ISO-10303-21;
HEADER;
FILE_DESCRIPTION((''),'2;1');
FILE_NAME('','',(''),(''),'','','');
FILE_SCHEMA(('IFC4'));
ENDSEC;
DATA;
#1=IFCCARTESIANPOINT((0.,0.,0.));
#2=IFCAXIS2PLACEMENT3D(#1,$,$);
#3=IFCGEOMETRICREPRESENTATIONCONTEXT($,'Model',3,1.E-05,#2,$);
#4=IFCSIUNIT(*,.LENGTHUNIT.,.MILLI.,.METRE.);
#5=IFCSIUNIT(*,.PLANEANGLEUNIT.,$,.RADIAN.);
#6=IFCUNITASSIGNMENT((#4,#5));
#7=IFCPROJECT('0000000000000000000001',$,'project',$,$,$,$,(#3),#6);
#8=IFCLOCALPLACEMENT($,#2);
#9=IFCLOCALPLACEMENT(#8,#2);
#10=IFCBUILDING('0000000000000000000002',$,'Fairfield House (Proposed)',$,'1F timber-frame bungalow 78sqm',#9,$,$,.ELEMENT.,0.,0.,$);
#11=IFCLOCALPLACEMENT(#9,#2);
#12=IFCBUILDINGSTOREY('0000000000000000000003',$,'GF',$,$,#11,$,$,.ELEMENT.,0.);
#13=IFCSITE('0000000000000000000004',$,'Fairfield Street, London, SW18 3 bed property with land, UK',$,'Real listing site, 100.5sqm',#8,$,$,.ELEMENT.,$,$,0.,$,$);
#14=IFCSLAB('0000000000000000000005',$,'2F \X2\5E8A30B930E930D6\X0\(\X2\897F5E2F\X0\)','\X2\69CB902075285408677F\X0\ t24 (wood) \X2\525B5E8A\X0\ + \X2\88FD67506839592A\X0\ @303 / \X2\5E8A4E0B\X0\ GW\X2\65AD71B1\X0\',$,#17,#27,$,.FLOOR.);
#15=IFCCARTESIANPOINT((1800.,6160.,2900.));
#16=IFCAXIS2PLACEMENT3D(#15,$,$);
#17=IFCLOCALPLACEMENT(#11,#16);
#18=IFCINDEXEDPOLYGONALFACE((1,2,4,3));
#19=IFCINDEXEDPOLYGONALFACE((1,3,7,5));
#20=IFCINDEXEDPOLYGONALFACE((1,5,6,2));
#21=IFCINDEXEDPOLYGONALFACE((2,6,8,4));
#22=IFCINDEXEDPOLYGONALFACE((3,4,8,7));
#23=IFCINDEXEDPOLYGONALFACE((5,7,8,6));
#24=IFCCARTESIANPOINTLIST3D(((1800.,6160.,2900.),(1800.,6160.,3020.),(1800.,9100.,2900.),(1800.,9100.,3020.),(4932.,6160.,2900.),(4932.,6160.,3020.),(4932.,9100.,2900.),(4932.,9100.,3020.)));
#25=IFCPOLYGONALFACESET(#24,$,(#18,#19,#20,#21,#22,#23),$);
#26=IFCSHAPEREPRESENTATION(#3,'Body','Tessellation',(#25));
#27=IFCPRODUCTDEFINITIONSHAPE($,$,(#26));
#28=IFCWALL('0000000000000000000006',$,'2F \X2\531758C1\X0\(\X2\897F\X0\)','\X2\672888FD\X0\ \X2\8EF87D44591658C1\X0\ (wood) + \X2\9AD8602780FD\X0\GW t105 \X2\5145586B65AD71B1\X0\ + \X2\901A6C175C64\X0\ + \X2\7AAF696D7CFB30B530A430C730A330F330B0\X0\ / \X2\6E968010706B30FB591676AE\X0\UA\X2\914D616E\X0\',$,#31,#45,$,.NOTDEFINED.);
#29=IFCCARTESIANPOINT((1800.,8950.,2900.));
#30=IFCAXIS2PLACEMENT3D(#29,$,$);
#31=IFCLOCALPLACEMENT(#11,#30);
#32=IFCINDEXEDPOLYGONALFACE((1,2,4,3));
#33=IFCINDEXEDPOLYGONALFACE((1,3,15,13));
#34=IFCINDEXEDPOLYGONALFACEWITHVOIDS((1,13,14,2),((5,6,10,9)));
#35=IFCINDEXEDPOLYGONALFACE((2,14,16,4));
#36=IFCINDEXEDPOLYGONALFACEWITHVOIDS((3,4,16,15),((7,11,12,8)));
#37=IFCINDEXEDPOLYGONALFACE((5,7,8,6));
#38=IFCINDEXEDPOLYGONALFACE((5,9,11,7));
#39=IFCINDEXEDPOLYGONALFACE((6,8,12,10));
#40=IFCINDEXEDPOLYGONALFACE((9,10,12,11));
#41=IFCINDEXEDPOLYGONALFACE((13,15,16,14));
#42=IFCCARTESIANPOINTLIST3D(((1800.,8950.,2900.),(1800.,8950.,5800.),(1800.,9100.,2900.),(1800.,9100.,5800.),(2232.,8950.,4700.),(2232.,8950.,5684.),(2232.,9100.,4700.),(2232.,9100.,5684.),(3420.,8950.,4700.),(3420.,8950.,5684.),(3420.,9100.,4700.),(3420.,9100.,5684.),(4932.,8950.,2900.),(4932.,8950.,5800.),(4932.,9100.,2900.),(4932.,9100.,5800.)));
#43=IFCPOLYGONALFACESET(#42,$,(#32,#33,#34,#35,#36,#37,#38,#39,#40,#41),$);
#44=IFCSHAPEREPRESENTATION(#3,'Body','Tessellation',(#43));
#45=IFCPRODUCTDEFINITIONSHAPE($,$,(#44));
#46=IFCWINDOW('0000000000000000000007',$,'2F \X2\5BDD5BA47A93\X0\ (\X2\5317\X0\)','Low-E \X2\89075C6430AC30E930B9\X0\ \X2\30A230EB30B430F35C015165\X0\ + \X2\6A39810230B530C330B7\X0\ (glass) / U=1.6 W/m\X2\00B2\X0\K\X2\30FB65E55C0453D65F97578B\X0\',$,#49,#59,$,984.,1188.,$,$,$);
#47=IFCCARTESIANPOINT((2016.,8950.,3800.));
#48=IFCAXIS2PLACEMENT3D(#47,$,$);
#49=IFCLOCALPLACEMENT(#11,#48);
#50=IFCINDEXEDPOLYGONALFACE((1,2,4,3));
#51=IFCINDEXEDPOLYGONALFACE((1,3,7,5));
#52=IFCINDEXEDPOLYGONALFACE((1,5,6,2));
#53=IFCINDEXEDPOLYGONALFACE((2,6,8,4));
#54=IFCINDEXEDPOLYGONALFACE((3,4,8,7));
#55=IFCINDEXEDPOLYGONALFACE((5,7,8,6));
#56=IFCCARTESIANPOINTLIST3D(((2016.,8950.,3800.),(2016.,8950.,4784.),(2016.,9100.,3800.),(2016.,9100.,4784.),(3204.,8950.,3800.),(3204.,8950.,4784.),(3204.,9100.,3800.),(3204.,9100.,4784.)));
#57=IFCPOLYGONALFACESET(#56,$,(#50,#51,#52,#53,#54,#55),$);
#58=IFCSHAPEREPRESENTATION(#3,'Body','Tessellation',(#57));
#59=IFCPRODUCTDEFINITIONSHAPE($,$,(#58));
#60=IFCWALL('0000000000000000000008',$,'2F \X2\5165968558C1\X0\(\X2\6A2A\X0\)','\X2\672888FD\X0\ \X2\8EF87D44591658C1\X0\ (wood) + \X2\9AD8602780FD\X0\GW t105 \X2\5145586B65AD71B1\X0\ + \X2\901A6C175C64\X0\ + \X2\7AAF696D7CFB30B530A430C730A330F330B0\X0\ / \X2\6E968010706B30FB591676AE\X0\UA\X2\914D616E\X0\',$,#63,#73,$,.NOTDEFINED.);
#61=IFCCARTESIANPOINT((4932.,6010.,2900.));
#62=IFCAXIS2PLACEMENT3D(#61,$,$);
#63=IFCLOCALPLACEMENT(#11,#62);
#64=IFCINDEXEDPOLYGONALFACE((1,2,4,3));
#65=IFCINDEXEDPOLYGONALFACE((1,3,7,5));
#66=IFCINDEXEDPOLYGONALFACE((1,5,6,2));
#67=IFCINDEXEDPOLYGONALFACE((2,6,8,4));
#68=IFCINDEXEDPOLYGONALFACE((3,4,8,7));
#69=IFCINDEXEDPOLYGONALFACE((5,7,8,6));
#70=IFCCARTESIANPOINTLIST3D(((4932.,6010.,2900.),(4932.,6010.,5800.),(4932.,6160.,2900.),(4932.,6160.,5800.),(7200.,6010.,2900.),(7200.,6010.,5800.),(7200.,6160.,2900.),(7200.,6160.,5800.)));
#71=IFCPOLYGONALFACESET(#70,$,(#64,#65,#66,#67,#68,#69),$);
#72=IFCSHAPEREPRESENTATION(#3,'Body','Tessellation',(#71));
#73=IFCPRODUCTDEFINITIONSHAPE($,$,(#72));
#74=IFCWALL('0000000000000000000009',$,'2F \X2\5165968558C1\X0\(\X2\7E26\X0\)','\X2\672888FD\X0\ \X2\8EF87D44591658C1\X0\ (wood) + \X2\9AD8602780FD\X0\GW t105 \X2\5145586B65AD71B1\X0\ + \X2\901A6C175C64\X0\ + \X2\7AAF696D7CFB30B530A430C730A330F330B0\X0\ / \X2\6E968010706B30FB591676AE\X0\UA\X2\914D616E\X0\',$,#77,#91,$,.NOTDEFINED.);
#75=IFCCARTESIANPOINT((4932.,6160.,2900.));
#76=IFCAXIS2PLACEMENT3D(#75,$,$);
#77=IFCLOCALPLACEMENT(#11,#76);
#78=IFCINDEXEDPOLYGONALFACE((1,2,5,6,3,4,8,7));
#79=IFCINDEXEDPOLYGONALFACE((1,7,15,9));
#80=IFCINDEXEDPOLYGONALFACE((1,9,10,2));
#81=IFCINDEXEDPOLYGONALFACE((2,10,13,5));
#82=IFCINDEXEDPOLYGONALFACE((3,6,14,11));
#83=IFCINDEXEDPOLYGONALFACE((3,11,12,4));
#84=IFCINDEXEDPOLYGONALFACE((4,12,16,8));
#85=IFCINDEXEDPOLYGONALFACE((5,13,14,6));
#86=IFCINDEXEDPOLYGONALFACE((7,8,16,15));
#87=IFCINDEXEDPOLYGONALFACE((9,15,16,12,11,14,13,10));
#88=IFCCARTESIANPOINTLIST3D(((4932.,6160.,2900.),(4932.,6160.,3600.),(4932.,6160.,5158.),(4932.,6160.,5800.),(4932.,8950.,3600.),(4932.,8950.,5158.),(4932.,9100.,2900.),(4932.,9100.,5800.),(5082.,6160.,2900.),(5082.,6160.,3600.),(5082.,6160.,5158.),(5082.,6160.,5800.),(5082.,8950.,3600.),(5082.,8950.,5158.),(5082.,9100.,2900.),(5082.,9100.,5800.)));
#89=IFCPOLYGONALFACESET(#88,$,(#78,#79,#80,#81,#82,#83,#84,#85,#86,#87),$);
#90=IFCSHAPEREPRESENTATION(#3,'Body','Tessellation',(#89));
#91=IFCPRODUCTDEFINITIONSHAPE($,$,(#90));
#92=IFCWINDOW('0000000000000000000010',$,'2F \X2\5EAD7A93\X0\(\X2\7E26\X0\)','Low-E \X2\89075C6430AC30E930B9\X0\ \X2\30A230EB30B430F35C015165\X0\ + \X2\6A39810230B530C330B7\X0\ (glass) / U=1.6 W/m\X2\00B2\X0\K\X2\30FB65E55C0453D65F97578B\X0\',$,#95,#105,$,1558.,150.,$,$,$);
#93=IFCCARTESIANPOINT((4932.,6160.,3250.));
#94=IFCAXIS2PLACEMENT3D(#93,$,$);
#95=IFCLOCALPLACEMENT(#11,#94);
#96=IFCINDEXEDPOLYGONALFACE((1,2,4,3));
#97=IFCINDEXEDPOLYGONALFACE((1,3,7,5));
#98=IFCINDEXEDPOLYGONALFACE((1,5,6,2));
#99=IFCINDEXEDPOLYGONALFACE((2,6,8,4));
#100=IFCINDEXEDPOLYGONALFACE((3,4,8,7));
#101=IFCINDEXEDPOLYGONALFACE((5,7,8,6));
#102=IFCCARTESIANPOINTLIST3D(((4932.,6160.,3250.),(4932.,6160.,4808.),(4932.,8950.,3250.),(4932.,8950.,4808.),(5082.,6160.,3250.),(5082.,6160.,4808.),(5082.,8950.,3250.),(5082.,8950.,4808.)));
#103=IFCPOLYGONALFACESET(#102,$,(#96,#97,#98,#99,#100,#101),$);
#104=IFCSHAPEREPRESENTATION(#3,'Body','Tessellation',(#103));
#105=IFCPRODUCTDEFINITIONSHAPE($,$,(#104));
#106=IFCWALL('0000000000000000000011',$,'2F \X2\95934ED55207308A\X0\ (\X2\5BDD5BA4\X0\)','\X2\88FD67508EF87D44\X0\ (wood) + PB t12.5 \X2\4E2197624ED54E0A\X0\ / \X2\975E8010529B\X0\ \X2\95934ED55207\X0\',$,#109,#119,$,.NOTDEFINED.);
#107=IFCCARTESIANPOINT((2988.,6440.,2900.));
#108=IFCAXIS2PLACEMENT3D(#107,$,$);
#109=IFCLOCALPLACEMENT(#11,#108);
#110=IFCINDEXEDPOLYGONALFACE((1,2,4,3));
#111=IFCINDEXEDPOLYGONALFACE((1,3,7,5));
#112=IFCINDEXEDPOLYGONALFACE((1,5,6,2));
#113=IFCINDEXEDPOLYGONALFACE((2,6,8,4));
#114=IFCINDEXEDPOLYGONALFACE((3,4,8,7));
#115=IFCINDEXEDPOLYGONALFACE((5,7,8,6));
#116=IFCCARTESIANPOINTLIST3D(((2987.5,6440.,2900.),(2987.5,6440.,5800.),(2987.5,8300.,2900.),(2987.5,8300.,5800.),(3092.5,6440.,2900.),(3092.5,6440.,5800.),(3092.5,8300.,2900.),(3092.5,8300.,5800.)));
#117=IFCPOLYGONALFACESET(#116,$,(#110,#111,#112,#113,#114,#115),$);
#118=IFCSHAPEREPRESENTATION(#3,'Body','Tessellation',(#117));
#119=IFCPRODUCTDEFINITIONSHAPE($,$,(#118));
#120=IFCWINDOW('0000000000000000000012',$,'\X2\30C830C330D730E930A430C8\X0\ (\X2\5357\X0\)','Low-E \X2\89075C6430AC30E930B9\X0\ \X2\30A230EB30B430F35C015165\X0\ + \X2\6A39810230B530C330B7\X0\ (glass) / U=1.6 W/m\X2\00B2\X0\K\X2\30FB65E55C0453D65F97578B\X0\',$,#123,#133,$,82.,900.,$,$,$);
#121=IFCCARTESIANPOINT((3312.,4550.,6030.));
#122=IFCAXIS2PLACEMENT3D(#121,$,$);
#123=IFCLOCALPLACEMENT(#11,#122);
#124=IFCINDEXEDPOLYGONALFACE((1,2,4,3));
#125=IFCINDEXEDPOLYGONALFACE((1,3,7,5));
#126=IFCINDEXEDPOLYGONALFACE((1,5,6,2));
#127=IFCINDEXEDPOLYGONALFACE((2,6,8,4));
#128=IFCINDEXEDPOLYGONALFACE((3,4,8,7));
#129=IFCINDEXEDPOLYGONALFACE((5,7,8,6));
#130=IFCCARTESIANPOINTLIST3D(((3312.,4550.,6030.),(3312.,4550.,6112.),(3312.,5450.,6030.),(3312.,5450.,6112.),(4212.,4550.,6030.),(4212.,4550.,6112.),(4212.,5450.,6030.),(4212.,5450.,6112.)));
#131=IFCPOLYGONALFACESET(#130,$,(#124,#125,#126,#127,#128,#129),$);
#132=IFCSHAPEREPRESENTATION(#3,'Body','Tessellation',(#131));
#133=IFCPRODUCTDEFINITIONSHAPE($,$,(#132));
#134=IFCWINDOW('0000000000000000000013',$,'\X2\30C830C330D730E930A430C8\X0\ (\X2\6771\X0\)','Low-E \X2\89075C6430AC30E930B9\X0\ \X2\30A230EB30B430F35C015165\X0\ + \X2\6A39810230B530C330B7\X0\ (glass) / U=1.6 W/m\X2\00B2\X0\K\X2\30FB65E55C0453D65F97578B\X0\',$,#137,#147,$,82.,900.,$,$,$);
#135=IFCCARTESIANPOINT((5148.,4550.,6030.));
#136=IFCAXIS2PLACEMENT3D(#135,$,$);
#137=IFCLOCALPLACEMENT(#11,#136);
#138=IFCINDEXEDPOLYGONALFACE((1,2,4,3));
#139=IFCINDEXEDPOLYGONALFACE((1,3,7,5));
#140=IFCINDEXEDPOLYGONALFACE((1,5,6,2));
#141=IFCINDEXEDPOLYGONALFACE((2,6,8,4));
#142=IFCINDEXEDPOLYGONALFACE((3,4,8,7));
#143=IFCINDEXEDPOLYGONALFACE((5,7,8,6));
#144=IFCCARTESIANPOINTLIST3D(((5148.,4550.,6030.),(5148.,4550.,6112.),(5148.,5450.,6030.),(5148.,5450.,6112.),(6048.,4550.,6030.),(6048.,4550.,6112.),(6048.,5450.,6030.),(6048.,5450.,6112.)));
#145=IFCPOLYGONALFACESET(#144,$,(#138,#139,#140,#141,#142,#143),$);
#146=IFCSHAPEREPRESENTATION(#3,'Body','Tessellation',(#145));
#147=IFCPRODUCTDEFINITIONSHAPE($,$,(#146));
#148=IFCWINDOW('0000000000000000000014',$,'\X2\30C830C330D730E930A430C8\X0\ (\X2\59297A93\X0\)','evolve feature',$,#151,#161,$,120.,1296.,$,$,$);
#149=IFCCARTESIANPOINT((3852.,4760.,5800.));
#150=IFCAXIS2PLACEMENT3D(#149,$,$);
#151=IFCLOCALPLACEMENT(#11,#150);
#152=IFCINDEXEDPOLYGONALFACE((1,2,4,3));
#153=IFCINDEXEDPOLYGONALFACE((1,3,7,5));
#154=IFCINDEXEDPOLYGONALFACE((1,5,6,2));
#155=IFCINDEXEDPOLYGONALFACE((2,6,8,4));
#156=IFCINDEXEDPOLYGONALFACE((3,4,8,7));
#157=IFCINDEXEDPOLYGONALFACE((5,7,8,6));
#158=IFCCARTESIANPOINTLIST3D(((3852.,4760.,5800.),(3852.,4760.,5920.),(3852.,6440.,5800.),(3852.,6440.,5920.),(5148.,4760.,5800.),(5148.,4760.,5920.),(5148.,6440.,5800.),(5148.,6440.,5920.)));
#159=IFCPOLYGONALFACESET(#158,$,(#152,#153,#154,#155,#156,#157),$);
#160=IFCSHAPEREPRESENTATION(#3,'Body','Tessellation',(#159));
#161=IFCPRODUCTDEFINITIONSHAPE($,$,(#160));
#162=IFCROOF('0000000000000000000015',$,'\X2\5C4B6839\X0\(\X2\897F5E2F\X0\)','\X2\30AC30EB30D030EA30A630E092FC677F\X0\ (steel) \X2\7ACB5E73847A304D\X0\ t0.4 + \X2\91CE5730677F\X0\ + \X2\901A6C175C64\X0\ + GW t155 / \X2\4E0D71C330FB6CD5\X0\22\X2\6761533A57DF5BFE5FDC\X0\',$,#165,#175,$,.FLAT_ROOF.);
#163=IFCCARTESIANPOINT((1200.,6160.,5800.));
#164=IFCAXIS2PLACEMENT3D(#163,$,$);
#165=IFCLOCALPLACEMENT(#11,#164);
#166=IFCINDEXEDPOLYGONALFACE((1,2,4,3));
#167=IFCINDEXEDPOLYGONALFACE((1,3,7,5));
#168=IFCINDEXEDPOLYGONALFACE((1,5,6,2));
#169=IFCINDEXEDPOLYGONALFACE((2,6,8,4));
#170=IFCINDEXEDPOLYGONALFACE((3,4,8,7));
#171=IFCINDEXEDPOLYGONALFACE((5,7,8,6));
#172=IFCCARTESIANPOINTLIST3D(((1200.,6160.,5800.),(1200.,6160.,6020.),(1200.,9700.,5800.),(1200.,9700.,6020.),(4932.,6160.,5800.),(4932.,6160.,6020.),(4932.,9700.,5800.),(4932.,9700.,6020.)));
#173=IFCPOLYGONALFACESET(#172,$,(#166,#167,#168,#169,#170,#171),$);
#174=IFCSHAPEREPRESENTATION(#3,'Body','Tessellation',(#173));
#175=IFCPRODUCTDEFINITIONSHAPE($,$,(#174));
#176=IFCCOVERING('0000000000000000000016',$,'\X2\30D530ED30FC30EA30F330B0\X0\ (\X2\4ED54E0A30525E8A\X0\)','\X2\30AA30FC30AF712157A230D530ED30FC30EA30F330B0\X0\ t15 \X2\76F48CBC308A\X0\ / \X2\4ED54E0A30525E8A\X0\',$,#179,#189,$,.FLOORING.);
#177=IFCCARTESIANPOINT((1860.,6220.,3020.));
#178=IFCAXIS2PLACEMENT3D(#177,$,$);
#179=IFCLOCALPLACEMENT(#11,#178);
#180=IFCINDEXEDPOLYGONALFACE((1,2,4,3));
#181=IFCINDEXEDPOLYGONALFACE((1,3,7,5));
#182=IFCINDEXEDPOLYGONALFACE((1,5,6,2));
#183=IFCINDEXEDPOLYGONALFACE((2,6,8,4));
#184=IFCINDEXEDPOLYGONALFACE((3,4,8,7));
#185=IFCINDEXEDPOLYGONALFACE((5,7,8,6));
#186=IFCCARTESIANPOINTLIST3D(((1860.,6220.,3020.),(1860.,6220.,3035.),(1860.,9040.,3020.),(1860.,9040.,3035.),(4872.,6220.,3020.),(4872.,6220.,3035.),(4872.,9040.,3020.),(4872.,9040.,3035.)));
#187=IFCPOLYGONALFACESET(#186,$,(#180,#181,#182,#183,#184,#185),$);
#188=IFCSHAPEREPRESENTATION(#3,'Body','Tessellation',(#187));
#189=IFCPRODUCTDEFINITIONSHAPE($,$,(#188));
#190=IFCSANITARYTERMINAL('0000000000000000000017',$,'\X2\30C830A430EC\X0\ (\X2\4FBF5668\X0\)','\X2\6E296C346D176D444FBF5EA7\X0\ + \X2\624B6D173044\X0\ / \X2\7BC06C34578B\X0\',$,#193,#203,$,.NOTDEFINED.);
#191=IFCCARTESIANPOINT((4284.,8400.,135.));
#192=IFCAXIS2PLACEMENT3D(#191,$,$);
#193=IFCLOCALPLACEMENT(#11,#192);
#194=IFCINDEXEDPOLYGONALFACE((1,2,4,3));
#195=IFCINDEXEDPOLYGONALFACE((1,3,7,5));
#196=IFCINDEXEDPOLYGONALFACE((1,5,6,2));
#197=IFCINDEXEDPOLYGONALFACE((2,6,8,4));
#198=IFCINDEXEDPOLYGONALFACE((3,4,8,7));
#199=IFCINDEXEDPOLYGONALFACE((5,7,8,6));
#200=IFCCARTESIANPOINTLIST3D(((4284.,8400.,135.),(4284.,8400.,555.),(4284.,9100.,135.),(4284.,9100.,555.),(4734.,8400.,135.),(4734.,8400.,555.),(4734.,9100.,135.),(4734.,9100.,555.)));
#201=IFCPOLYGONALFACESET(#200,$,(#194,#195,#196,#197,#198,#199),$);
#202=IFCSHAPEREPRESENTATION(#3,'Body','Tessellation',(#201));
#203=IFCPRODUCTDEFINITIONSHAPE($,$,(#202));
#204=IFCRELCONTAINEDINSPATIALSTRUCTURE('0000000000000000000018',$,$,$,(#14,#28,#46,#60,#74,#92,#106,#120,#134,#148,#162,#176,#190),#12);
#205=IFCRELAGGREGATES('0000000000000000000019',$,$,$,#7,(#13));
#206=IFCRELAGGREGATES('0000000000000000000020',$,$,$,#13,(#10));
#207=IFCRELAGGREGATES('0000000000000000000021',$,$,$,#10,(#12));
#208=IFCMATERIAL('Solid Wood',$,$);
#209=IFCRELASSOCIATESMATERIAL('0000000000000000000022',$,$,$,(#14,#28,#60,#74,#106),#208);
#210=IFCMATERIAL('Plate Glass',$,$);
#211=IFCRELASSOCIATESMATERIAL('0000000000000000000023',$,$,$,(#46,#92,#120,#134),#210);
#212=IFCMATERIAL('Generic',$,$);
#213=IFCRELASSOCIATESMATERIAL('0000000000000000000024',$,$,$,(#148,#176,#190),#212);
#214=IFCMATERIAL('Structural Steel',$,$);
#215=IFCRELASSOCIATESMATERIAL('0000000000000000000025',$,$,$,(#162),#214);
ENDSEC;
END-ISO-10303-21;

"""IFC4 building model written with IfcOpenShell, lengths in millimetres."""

from ifc_helpers import new_model, si_unit, frame, frame_2d, origin, place, context, project, spatial, rectangle, extrude, material, element, fill, save


model = new_model("IFC4")

# Units and contexts
model_context = context("Model", 3, precision=1e-05, world=origin())
ifc_project = project(units=[si_unit("LENGTHUNIT", "METRE", prefix="MILLI"), si_unit("PLANEANGLEUNIT", "RADIAN")], contexts=[model_context])

# Site, building, storey
site_placement = place(None, origin())
site = spatial("IfcSite", under=ifc_project, at=site_placement, Name="Fairfield Street, London, SW18 3 bed property with land, UK", ObjectType="Real listing site, 100.5sqm", CompositionType="ELEMENT", RefElevation=0.0)
building_placement = place(site_placement, origin())
building = spatial("IfcBuilding", under=site, at=building_placement, Name="Fairfield House (Proposed)", ObjectType="1F timber-frame bungalow 78sqm", CompositionType="ELEMENT", ElevationOfRefHeight=0.0, ElevationOfTerrain=0.0)
storey_placement = place(building_placement, origin())
storey = spatial("IfcBuildingStorey", under=building, at=storey_placement, Name="GF", CompositionType="ELEMENT", Elevation=0.0)

# Slab
ifc_material_1 = material(Name="Solid Wood")
slab_placement = place(storey_placement, frame((1800.0, 6160.0, 2900.0)))
element("IfcSlab", 1, at=slab_placement, inside=storey, material=ifc_material_1, Name="2F 床スラブ(西帯)", Description="構造用合板 t24 (wood) 剛床 + 製材根太 @303 / 床下 GW断熱", PredefinedType="FLOOR", context=model_context, shape_type="SweptSolid", body=[
    extrude(rectangle(XDim=3132.0, YDim=2940.0, at=frame_2d((1566.0, 1470.0))), frame((1800.0, 6160.0, 2900.0)), (0.0, 0.0, 1.0), 120.0),
])

# Wall, opening, window
wall_1_placement = place(storey_placement, frame((1800.0, 8950.0, 2900.0)))
wall_1 = element("IfcWall", 2, at=wall_1_placement, inside=storey, material=ifc_material_1, Name="2F 北壁(西)", Description="木製 軸組外壁 (wood) + 高性能GW t105 充填断熱 + 通気層 + 窯業系サイディング / 準耐火・外皮UA配慮", PredefinedType="NOTDEFINED", context=model_context, shape_type="SweptSolid", body=[
    extrude(rectangle(XDim=3132.0, YDim=150.0, at=frame_2d((1566.0, 75.0))), frame((1800.0, 8950.0, 2900.0)), (0.0, 0.0, 1.0), 2900.0),
])
opening_1_placement = place(storey_placement, frame((2016.0, 8950.0, 3800.0)))
opening_1 = element("IfcOpeningElement", 3, at=opening_1_placement, cuts=wall_1, PredefinedType="NOTDEFINED", context=model_context, shape_type="SweptSolid", body=[
    extrude(rectangle(XDim=1188.0, YDim=150.0, at=frame_2d((594.0, 75.0))), frame((2016.0, 8950.0, 3800.0)), (0.0, 0.0, 1.0), 984.0),
])
ifc_material_2 = material(Name="Plate Glass")
window_1_placement = place(storey_placement, frame((2016.0, 8950.0, 3800.0)))
window_1 = element("IfcWindow", 4, at=window_1_placement, inside=storey, material=ifc_material_2, Name="2F 寝室窓 (北)", Description="Low-E 複層ガラス アルゴン封入 + 樹脂サッシ (glass) / U=1.6 W/m²K・日射取得型", OverallHeight=984.0, OverallWidth=1188.0, context=model_context, shape_type="SweptSolid", body=[
    extrude(rectangle(XDim=1188.0, YDim=150.0, at=frame_2d((594.0, 75.0))), frame((2016.0, 8950.0, 3800.0)), (0.0, 0.0, 1.0), 984.0),
])
fill(opening_1, window_1)

# Wall
wall_2_placement = place(storey_placement, frame((4932.0, 6010.0, 2900.0)))
element("IfcWall", 5, at=wall_2_placement, inside=storey, material=ifc_material_1, Name="2F 入隅壁(横)", Description="木製 軸組外壁 (wood) + 高性能GW t105 充填断熱 + 通気層 + 窯業系サイディング / 準耐火・外皮UA配慮", PredefinedType="NOTDEFINED", context=model_context, shape_type="SweptSolid", body=[
    extrude(rectangle(XDim=2268.0, YDim=150.0, at=frame_2d((1134.0, 75.0))), frame((4932.0, 6010.0, 2900.0)), (0.0, 0.0, 1.0), 2900.0),
])

# Wall, opening, window
wall_3_placement = place(storey_placement, frame((4932.0, 6160.0, 2900.0)))
wall_3 = element("IfcWall", 6, at=wall_3_placement, inside=storey, material=ifc_material_1, Name="2F 入隅壁(縦)", Description="木製 軸組外壁 (wood) + 高性能GW t105 充填断熱 + 通気層 + 窯業系サイディング / 準耐火・外皮UA配慮", PredefinedType="NOTDEFINED", context=model_context, shape_type="SweptSolid", body=[
    extrude(rectangle(XDim=150.0, YDim=2940.0, at=frame_2d((75.0, 1470.0))), frame((4932.0, 6160.0, 2900.0)), (0.0, 0.0, 1.0), 2900.0),
])
opening_2_placement = place(storey_placement, frame((4932.0, 6160.0, 3250.0)))
opening_2 = element("IfcOpeningElement", 7, at=opening_2_placement, cuts=wall_3, PredefinedType="NOTDEFINED", context=model_context, shape_type="SweptSolid", body=[
    extrude(rectangle(XDim=150.0, YDim=2790.0, at=frame_2d((75.0, 1395.0))), frame((4932.0, 6160.0, 3250.0)), (0.0, 0.0, 1.0), 1558.0),
])
window_2_placement = place(storey_placement, frame((4932.0, 6160.0, 3250.0)))
window_2 = element("IfcWindow", 8, at=window_2_placement, inside=storey, material=ifc_material_2, Name="2F 庭窓(縦)", Description="Low-E 複層ガラス アルゴン封入 + 樹脂サッシ (glass) / U=1.6 W/m²K・日射取得型", OverallHeight=1558.0, OverallWidth=150.0, context=model_context, shape_type="SweptSolid", body=[
    extrude(rectangle(XDim=150.0, YDim=2790.0, at=frame_2d((75.0, 1395.0))), frame((4932.0, 6160.0, 3250.0)), (0.0, 0.0, 1.0), 1558.0),
])
fill(opening_2, window_2)

# Wall
wall_4_placement = place(storey_placement, frame((2988.0, 6440.0, 2900.0)))
element("IfcWall", 9, at=wall_4_placement, inside=storey, material=ifc_material_1, Name="2F 間仕切り (寝室)", Description="製材軸組 (wood) + PB t12.5 両面仕上 / 非耐力 間仕切", PredefinedType="NOTDEFINED", context=model_context, shape_type="SweptSolid", body=[
    extrude(rectangle(XDim=105.0, YDim=1860.0, at=frame_2d((52.0, 930.0))), frame((2988.0, 6440.0, 2900.0)), (0.0, 0.0, 1.0), 2900.0),
])

# Windows
window_3_placement = place(storey_placement, frame((3312.0, 4550.0, 6030.0)))
element("IfcWindow", 10, at=window_3_placement, inside=storey, material=ifc_material_2, Name="トップライト (南)", Description="Low-E 複層ガラス アルゴン封入 + 樹脂サッシ (glass) / U=1.6 W/m²K・日射取得型", OverallHeight=82.0, OverallWidth=900.0, context=model_context, shape_type="SweptSolid", body=[
    extrude(rectangle(XDim=900.0, YDim=900.0, at=frame_2d((450.0, 450.0))), frame((3312.0, 4550.0, 6030.0)), (0.0, 0.0, 1.0), 82.0),
])
window_4_placement = place(storey_placement, frame((5148.0, 4550.0, 6030.0)))
element("IfcWindow", 11, at=window_4_placement, inside=storey, material=ifc_material_2, Name="トップライト (東)", Description="Low-E 複層ガラス アルゴン封入 + 樹脂サッシ (glass) / U=1.6 W/m²K・日射取得型", OverallHeight=82.0, OverallWidth=900.0, context=model_context, shape_type="SweptSolid", body=[
    extrude(rectangle(XDim=900.0, YDim=900.0, at=frame_2d((450.0, 450.0))), frame((5148.0, 4550.0, 6030.0)), (0.0, 0.0, 1.0), 82.0),
])
ifc_material_3 = material(Name="Generic")
window_5_placement = place(storey_placement, frame((3852.0, 4760.0, 5800.0)))
element("IfcWindow", 12, at=window_5_placement, inside=storey, material=ifc_material_3, Name="トップライト (天窓)", Description="evolve feature", OverallHeight=120.0, OverallWidth=1296.0, context=model_context, shape_type="SweptSolid", body=[
    extrude(rectangle(XDim=1296.0, YDim=1680.0, at=frame_2d((648.0, 840.0))), frame((3852.0, 4760.0, 5800.0)), (0.0, 0.0, 1.0), 120.0),
])

# Roof
ifc_material_4 = material(Name="Structural Steel")
for number, where, name in (
    (13, (1200.0, 6160.0, 5800.0), "屋根(西帯)"),
):
    element("IfcRoof", number, at=place(storey_placement, frame(where)), inside=storey, material=ifc_material_4, Name=name, Description="ガルバリウム鋼板 (steel) 立平葺き t0.4 + 野地板 + 通気層 + GW t155 / 不燃・法22条区域対応", PredefinedType="FLAT_ROOF", context=model_context, shape_type="SweptSolid", body=[
        extrude(rectangle(XDim=3732.0, YDim=3540.0, at=frame_2d((1866.0, 1770.0))), frame((1200.0, 6160.0, 5800.0)), (0.0, 0.0, 1.0), 220.0),
    ])

# Covering
covering_placement = place(storey_placement, frame((1860.0, 6220.0, 3020.0)))
element("IfcCovering", 14, at=covering_placement, inside=storey, material=ifc_material_3, Name="フローリング (仕上げ床)", Description="オーク無垢フローリング t15 直貼り / 仕上げ床", PredefinedType="FLOORING", context=model_context, shape_type="SweptSolid", body=[
    extrude(rectangle(XDim=3012.0, YDim=2820.0, at=frame_2d((1506.0, 1410.0))), frame((1860.0, 6220.0, 3020.0)), (0.0, 0.0, 1.0), 15.0),
])

# Sanitary terminal
sanitary_terminal_placement = place(storey_placement, frame((4284.0, 8400.0, 135.0)))
element("IfcSanitaryTerminal", 15, at=sanitary_terminal_placement, inside=storey, material=ifc_material_3, Name="トイレ (便器)", Description="温水洗浄便座 + 手洗い / 節水型", PredefinedType="NOTDEFINED", context=model_context, shape_type="SweptSolid", body=[
    extrude(rectangle(XDim=450.0, YDim=700.0, at=frame_2d((225.0, 350.0))), frame((4284.0, 8400.0, 135.0)), (0.0, 0.0, 1.0), 420.0),
])

save(model, "model.ifc")
